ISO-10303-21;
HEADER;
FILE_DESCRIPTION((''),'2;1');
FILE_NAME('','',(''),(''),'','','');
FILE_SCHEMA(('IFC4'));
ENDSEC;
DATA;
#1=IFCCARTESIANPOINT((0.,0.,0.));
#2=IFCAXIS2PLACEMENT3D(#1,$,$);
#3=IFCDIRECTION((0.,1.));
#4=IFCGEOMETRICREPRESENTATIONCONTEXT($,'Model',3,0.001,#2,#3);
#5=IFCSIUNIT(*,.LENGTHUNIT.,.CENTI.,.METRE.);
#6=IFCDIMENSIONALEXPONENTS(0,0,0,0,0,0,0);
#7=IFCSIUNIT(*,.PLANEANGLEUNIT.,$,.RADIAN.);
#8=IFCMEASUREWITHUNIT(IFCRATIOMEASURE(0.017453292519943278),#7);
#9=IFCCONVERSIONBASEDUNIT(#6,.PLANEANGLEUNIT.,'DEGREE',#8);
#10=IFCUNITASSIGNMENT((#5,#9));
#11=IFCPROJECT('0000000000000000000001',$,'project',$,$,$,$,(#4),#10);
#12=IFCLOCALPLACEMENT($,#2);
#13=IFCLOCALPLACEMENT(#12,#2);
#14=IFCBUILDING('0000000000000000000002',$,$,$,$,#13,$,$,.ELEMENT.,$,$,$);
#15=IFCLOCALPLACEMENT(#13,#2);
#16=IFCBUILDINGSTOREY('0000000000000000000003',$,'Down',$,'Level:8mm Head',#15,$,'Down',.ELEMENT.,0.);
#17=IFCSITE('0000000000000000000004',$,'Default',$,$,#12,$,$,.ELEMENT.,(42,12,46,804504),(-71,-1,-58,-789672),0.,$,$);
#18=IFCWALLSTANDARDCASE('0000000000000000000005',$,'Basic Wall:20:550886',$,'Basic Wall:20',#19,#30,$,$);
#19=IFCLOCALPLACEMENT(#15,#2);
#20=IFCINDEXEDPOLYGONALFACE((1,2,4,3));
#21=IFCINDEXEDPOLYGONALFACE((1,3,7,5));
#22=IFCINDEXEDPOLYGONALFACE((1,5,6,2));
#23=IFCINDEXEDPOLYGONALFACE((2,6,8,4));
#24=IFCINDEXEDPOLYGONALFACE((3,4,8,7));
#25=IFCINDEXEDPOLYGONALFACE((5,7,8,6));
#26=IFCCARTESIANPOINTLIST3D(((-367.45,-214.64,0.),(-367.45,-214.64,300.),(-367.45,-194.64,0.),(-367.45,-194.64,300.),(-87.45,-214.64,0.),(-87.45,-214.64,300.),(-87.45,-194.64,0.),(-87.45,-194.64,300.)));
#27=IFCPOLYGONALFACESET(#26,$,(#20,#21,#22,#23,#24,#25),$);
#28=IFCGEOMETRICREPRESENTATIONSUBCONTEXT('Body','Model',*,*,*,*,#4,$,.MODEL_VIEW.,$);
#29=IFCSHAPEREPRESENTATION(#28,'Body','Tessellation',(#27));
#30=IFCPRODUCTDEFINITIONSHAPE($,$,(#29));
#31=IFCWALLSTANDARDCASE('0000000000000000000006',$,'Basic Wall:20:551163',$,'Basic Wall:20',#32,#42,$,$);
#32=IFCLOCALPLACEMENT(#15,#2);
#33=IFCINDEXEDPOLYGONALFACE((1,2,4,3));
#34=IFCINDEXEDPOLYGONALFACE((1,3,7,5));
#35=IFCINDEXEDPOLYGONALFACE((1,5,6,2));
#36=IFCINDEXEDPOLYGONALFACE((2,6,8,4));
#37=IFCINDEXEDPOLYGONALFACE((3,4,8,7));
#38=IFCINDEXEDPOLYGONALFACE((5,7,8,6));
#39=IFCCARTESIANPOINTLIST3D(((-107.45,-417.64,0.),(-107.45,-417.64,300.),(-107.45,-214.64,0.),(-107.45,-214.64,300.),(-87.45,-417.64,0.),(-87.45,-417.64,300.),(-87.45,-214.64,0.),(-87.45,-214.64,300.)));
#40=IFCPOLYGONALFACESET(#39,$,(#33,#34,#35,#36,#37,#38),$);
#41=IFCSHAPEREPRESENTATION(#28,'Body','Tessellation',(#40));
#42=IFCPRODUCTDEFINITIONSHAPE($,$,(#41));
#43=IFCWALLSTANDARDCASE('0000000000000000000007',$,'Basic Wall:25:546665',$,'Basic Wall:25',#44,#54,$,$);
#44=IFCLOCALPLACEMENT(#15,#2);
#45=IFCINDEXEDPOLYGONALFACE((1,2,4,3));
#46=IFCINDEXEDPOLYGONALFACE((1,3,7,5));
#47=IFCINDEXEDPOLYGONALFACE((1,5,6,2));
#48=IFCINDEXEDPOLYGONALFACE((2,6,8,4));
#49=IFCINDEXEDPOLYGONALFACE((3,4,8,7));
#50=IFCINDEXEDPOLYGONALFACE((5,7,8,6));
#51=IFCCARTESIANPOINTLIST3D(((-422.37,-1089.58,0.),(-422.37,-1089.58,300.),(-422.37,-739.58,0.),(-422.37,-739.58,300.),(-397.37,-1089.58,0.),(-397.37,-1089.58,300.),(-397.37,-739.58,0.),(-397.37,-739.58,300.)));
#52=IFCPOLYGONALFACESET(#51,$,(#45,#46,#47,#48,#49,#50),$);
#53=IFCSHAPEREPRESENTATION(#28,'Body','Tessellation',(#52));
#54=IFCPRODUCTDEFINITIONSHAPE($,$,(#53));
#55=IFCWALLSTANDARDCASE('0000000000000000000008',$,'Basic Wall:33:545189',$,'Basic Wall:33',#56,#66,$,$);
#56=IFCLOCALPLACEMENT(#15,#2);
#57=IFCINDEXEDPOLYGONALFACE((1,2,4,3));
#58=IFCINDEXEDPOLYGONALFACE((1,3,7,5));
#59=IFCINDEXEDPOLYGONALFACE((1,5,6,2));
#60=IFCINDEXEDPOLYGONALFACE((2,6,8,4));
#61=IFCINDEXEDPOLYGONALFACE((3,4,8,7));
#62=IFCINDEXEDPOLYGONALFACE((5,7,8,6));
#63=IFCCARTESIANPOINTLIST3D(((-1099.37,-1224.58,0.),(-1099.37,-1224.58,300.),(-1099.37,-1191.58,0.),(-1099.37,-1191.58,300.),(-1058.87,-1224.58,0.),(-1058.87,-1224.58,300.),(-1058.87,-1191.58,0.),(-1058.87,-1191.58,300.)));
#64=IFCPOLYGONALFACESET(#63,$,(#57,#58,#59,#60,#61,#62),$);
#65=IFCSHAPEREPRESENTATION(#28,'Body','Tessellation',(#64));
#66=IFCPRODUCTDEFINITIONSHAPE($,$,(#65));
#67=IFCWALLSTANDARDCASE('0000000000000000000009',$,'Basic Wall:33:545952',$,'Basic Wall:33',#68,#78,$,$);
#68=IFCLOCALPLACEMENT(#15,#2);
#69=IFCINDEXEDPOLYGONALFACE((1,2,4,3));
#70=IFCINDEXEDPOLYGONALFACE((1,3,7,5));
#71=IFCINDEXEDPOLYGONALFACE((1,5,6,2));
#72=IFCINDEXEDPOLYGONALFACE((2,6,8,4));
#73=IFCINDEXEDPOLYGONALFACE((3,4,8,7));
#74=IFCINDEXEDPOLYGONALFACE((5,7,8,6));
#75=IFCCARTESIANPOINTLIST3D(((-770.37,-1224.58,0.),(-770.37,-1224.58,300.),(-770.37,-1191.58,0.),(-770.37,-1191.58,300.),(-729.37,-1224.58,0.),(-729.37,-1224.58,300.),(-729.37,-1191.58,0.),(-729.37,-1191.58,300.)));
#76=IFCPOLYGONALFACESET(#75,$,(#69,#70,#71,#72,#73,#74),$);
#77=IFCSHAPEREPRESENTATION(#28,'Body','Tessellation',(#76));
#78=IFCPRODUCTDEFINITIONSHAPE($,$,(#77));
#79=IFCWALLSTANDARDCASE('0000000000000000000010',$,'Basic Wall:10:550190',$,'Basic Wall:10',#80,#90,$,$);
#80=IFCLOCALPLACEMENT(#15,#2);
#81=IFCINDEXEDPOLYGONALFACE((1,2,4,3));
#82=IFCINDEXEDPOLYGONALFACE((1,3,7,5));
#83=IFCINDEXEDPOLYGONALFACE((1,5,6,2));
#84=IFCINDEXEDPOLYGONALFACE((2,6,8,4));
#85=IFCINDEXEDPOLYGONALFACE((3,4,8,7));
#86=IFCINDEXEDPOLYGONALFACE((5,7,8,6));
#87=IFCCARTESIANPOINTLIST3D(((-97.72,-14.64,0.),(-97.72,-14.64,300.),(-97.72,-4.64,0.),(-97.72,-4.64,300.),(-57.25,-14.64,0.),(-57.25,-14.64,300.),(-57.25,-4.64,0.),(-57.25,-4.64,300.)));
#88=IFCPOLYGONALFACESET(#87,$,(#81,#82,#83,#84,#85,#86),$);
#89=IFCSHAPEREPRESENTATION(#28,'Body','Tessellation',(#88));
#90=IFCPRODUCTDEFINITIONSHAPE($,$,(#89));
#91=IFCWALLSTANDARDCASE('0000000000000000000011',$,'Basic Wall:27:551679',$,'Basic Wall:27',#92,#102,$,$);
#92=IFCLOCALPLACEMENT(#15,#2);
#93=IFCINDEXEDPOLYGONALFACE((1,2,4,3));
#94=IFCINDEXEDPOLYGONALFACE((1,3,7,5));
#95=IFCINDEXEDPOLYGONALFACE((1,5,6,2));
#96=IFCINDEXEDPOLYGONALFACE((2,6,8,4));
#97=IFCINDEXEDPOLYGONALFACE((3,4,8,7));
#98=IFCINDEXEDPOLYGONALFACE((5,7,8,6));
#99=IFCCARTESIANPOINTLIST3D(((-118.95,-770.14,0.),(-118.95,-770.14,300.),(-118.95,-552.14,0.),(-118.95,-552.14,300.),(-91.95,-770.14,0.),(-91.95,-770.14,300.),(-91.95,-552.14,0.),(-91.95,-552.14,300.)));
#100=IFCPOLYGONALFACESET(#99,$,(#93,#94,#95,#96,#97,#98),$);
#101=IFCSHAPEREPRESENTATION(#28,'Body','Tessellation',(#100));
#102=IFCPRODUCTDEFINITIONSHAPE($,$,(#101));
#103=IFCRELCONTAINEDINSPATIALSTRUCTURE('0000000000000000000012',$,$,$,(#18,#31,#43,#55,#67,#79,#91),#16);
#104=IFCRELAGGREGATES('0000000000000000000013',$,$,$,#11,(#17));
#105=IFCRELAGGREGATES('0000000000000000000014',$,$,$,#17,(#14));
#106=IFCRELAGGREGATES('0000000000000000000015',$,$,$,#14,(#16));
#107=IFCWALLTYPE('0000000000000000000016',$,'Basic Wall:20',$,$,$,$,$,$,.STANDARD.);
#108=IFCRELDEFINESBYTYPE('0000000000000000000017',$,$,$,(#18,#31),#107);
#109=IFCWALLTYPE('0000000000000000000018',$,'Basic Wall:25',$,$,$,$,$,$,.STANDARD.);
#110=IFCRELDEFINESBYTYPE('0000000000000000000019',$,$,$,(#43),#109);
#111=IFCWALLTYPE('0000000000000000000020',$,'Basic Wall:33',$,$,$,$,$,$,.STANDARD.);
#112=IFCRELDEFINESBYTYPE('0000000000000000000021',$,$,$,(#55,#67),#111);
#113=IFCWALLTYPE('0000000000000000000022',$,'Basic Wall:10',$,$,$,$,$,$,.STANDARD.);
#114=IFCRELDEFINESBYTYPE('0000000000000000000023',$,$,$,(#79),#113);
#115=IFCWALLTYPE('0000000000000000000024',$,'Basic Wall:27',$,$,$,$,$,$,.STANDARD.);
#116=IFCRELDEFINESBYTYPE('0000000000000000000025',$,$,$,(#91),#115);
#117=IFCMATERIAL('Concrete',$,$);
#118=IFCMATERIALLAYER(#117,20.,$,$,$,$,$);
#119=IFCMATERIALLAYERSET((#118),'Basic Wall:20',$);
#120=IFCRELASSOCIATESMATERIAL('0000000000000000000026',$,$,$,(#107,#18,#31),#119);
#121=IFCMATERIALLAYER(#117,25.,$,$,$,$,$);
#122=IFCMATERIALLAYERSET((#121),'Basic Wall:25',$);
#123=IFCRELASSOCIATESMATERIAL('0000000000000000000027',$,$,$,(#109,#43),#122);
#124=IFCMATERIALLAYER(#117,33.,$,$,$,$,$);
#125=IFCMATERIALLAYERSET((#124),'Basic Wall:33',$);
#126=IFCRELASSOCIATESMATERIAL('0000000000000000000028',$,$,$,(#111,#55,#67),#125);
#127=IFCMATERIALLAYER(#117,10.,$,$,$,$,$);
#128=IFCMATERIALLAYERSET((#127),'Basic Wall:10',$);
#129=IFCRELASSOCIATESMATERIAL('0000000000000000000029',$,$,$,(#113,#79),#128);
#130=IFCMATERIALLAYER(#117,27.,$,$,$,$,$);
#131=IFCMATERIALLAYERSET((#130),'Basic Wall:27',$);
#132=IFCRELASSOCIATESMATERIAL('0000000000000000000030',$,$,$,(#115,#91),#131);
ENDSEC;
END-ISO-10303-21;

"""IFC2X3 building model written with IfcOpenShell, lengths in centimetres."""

from ifc_helpers import new_model, entity, si_unit, converted_unit, direction, frame, frame_2d, origin, place, context, subcontext, project, spatial, rectangle, extrude, material, layer, layer_set, layer_usage, type_object, element, save


model = new_model("IFC2X3")

# Units and contexts
model_context = context("Model", 3, precision=0.001, world=origin(), true_north=direction((0.0, 1.0)))
body_context = subcontext(model_context, "Body", "Model", "MODEL_VIEW")
ifc_project = project(units=[si_unit("LENGTHUNIT", "METRE", prefix="CENTI"), converted_unit("PLANEANGLEUNIT", "DEGREE", entity("IfcRatioMeasure", 0.017453292519943278), si_unit("PLANEANGLEUNIT", "RADIAN"), dimensions=[0, 0, 0, 0, 0, 0, 0])], contexts=[model_context])

# Site, building, storey
site_placement = place(None, origin())
site = spatial("IfcSite", under=ifc_project, at=site_placement, Name="Default", CompositionType="ELEMENT", RefLatitude=(42, 12, 46, 804504), RefLongitude=(-71, -1, -58, -789672), RefElevation=0.0)
building_placement = place(site_placement, origin())
building = spatial("IfcBuilding", under=site, at=building_placement, CompositionType="ELEMENT")
storey_placement = place(building_placement, origin())
storey = spatial("IfcBuildingStorey", under=building, at=storey_placement, Name="Down", ObjectType="Level:8mm Head", LongName="Down", CompositionType="ELEMENT", Elevation=0.0)

# Walls
ifc_material = material(Name="Concrete")
ifc_layer_1 = layer(ifc_material, 20.0)
ifc_layer_set_1 = layer_set([ifc_layer_1], Name="Basic Wall:20")
wall_type_1 = type_object("IfcWallType", Name="Basic Wall:20", PredefinedType="STANDARD", material=ifc_layer_set_1)
ifc_layer_usage_1 = layer_usage(ifc_layer_set_1, "AXIS2", "POSITIVE", -10.0)
wall_1_placement = place(storey_placement, frame((-367.45, -204.64, 0.0)))
element("IfcWallStandardCase", 1, at=wall_1_placement, inside=storey, type_object=wall_type_1, material=ifc_layer_usage_1, Name="Basic Wall:20:550886", ObjectType="Basic Wall:20", context=body_context, shape_type="SweptSolid", body=[
    extrude(rectangle(XDim=280.0, YDim=20.0, at=frame_2d((140.0, 0.0), x_axis=(-1.0, 0.0))), origin(), (0.0, 0.0, 1.0), 300.0),
])
ifc_layer_usage_2 = layer_usage(ifc_layer_set_1, "AXIS2", "NEGATIVE", 10.0)
wall_2_placement = place(storey_placement, frame((-97.45, -214.64, 0.0), z_axis=(0.0, 0.0, 1.0), x_axis=(0.0, -1.0, 0.0)))
element("IfcWallStandardCase", 2, at=wall_2_placement, inside=storey, type_object=wall_type_1, material=ifc_layer_usage_2, Name="Basic Wall:20:551163", ObjectType="Basic Wall:20", context=body_context, shape_type="SweptSolid", body=[
    extrude(rectangle(XDim=203.0, YDim=20.0, at=frame_2d((101.5, 0.0), x_axis=(-1.0, 0.0))), origin(), (0.0, 0.0, 1.0), 300.0),
])
ifc_layer_2 = layer(ifc_material, 25.0)
ifc_layer_set_2 = layer_set([ifc_layer_2], Name="Basic Wall:25")
ifc_layer_usage_3 = layer_usage(ifc_layer_set_2, "AXIS2", "POSITIVE", -12.5)
wall_type_2 = type_object("IfcWallType", Name="Basic Wall:25", PredefinedType="STANDARD", material=ifc_layer_set_2)
wall_3_placement = place(storey_placement, frame((-409.87, -1089.58, 0.0), z_axis=(0.0, 0.0, 1.0), x_axis=(0.0, 1.0, 0.0)))
element("IfcWallStandardCase", 3, at=wall_3_placement, inside=storey, type_object=wall_type_2, material=ifc_layer_usage_3, Name="Basic Wall:25:546665", ObjectType="Basic Wall:25", context=body_context, shape_type="SweptSolid", body=[
    extrude(rectangle(XDim=350.0, YDim=25.0, at=frame_2d((175.0, 0.0), x_axis=(-1.0, 0.0))), origin(), (0.0, 0.0, 1.0), 300.0),
])
ifc_layer_3 = layer(ifc_material, 33.0)
ifc_layer_set_3 = layer_set([ifc_layer_3], Name="Basic Wall:33")
ifc_layer_usage_4 = layer_usage(ifc_layer_set_3, "AXIS2", "NEGATIVE", 16.5)
wall_type_3 = type_object("IfcWallType", Name="Basic Wall:33", PredefinedType="STANDARD", material=ifc_layer_set_3)
wall_4_placement = place(storey_placement, frame((-1099.37, -1208.08, 0.0)))
element("IfcWallStandardCase", 4, at=wall_4_placement, inside=storey, type_object=wall_type_3, material=ifc_layer_usage_4, Name="Basic Wall:33:545189", ObjectType="Basic Wall:33", context=body_context, shape_type="SweptSolid", body=[
    extrude(rectangle(XDim=40.5, YDim=33.0, at=frame_2d((20.25, 0.0), x_axis=(-1.0, 0.0))), origin(), (0.0, 0.0, 1.0), 300.0),
])
ifc_layer_usage_5 = layer_usage(ifc_layer_set_3, "AXIS2", "POSITIVE", -16.5)
wall_5_placement = place(storey_placement, frame((-729.37, -1208.08, 0.0), z_axis=(0.0, 0.0, 1.0), x_axis=(-1.0, 0.0, 0.0)))
element("IfcWallStandardCase", 5, at=wall_5_placement, inside=storey, type_object=wall_type_3, material=ifc_layer_usage_5, Name="Basic Wall:33:545952", ObjectType="Basic Wall:33", context=body_context, shape_type="SweptSolid", body=[
    extrude(rectangle(XDim=41.0, YDim=33.0, at=frame_2d((20.5, 0.0), x_axis=(-1.0, 0.0))), origin(), (0.0, 0.0, 1.0), 300.0),
])
ifc_layer_4 = layer(ifc_material, 10.0)
ifc_layer_set_4 = layer_set([ifc_layer_4], Name="Basic Wall:10")
ifc_layer_usage_6 = layer_usage(ifc_layer_set_4, "AXIS2", "POSITIVE", -5.0)
wall_type_4 = type_object("IfcWallType", Name="Basic Wall:10", PredefinedType="STANDARD", material=ifc_layer_set_4)
wall_6_placement = place(storey_placement, frame((-97.72, -9.64, 0.0)))
element("IfcWallStandardCase", 6, at=wall_6_placement, inside=storey, type_object=wall_type_4, material=ifc_layer_usage_6, Name="Basic Wall:10:550190", ObjectType="Basic Wall:10", context=body_context, shape_type="SweptSolid", body=[
    extrude(rectangle(XDim=40.47, YDim=10.0, at=frame_2d((20.24, 0.0), x_axis=(-1.0, 0.0))), origin(), (0.0, 0.0, 1.0), 300.0),
])
ifc_layer_5 = layer(ifc_material, 27.0)
ifc_layer_set_5 = layer_set([ifc_layer_5], Name="Basic Wall:27")
ifc_layer_usage_7 = layer_usage(ifc_layer_set_5, "AXIS2", "NEGATIVE", 13.5)
wall_type_5 = type_object("IfcWallType", Name="Basic Wall:27", PredefinedType="STANDARD", material=ifc_layer_set_5)
wall_7_placement = place(storey_placement, frame((-105.45, -552.14, 0.0), z_axis=(0.0, 0.0, 1.0), x_axis=(0.0, -1.0, 0.0)))
element("IfcWallStandardCase", 7, at=wall_7_placement, inside=storey, type_object=wall_type_5, material=ifc_layer_usage_7, Name="Basic Wall:27:551679", ObjectType="Basic Wall:27", context=body_context, shape_type="SweptSolid", body=[
    extrude(rectangle(XDim=218.0, YDim=27.0, at=frame_2d((109.0, 0.0), x_axis=(-1.0, 0.0))), origin(), (0.0, 0.0, 1.0), 300.0),
])

save(model, "model.ifc")
